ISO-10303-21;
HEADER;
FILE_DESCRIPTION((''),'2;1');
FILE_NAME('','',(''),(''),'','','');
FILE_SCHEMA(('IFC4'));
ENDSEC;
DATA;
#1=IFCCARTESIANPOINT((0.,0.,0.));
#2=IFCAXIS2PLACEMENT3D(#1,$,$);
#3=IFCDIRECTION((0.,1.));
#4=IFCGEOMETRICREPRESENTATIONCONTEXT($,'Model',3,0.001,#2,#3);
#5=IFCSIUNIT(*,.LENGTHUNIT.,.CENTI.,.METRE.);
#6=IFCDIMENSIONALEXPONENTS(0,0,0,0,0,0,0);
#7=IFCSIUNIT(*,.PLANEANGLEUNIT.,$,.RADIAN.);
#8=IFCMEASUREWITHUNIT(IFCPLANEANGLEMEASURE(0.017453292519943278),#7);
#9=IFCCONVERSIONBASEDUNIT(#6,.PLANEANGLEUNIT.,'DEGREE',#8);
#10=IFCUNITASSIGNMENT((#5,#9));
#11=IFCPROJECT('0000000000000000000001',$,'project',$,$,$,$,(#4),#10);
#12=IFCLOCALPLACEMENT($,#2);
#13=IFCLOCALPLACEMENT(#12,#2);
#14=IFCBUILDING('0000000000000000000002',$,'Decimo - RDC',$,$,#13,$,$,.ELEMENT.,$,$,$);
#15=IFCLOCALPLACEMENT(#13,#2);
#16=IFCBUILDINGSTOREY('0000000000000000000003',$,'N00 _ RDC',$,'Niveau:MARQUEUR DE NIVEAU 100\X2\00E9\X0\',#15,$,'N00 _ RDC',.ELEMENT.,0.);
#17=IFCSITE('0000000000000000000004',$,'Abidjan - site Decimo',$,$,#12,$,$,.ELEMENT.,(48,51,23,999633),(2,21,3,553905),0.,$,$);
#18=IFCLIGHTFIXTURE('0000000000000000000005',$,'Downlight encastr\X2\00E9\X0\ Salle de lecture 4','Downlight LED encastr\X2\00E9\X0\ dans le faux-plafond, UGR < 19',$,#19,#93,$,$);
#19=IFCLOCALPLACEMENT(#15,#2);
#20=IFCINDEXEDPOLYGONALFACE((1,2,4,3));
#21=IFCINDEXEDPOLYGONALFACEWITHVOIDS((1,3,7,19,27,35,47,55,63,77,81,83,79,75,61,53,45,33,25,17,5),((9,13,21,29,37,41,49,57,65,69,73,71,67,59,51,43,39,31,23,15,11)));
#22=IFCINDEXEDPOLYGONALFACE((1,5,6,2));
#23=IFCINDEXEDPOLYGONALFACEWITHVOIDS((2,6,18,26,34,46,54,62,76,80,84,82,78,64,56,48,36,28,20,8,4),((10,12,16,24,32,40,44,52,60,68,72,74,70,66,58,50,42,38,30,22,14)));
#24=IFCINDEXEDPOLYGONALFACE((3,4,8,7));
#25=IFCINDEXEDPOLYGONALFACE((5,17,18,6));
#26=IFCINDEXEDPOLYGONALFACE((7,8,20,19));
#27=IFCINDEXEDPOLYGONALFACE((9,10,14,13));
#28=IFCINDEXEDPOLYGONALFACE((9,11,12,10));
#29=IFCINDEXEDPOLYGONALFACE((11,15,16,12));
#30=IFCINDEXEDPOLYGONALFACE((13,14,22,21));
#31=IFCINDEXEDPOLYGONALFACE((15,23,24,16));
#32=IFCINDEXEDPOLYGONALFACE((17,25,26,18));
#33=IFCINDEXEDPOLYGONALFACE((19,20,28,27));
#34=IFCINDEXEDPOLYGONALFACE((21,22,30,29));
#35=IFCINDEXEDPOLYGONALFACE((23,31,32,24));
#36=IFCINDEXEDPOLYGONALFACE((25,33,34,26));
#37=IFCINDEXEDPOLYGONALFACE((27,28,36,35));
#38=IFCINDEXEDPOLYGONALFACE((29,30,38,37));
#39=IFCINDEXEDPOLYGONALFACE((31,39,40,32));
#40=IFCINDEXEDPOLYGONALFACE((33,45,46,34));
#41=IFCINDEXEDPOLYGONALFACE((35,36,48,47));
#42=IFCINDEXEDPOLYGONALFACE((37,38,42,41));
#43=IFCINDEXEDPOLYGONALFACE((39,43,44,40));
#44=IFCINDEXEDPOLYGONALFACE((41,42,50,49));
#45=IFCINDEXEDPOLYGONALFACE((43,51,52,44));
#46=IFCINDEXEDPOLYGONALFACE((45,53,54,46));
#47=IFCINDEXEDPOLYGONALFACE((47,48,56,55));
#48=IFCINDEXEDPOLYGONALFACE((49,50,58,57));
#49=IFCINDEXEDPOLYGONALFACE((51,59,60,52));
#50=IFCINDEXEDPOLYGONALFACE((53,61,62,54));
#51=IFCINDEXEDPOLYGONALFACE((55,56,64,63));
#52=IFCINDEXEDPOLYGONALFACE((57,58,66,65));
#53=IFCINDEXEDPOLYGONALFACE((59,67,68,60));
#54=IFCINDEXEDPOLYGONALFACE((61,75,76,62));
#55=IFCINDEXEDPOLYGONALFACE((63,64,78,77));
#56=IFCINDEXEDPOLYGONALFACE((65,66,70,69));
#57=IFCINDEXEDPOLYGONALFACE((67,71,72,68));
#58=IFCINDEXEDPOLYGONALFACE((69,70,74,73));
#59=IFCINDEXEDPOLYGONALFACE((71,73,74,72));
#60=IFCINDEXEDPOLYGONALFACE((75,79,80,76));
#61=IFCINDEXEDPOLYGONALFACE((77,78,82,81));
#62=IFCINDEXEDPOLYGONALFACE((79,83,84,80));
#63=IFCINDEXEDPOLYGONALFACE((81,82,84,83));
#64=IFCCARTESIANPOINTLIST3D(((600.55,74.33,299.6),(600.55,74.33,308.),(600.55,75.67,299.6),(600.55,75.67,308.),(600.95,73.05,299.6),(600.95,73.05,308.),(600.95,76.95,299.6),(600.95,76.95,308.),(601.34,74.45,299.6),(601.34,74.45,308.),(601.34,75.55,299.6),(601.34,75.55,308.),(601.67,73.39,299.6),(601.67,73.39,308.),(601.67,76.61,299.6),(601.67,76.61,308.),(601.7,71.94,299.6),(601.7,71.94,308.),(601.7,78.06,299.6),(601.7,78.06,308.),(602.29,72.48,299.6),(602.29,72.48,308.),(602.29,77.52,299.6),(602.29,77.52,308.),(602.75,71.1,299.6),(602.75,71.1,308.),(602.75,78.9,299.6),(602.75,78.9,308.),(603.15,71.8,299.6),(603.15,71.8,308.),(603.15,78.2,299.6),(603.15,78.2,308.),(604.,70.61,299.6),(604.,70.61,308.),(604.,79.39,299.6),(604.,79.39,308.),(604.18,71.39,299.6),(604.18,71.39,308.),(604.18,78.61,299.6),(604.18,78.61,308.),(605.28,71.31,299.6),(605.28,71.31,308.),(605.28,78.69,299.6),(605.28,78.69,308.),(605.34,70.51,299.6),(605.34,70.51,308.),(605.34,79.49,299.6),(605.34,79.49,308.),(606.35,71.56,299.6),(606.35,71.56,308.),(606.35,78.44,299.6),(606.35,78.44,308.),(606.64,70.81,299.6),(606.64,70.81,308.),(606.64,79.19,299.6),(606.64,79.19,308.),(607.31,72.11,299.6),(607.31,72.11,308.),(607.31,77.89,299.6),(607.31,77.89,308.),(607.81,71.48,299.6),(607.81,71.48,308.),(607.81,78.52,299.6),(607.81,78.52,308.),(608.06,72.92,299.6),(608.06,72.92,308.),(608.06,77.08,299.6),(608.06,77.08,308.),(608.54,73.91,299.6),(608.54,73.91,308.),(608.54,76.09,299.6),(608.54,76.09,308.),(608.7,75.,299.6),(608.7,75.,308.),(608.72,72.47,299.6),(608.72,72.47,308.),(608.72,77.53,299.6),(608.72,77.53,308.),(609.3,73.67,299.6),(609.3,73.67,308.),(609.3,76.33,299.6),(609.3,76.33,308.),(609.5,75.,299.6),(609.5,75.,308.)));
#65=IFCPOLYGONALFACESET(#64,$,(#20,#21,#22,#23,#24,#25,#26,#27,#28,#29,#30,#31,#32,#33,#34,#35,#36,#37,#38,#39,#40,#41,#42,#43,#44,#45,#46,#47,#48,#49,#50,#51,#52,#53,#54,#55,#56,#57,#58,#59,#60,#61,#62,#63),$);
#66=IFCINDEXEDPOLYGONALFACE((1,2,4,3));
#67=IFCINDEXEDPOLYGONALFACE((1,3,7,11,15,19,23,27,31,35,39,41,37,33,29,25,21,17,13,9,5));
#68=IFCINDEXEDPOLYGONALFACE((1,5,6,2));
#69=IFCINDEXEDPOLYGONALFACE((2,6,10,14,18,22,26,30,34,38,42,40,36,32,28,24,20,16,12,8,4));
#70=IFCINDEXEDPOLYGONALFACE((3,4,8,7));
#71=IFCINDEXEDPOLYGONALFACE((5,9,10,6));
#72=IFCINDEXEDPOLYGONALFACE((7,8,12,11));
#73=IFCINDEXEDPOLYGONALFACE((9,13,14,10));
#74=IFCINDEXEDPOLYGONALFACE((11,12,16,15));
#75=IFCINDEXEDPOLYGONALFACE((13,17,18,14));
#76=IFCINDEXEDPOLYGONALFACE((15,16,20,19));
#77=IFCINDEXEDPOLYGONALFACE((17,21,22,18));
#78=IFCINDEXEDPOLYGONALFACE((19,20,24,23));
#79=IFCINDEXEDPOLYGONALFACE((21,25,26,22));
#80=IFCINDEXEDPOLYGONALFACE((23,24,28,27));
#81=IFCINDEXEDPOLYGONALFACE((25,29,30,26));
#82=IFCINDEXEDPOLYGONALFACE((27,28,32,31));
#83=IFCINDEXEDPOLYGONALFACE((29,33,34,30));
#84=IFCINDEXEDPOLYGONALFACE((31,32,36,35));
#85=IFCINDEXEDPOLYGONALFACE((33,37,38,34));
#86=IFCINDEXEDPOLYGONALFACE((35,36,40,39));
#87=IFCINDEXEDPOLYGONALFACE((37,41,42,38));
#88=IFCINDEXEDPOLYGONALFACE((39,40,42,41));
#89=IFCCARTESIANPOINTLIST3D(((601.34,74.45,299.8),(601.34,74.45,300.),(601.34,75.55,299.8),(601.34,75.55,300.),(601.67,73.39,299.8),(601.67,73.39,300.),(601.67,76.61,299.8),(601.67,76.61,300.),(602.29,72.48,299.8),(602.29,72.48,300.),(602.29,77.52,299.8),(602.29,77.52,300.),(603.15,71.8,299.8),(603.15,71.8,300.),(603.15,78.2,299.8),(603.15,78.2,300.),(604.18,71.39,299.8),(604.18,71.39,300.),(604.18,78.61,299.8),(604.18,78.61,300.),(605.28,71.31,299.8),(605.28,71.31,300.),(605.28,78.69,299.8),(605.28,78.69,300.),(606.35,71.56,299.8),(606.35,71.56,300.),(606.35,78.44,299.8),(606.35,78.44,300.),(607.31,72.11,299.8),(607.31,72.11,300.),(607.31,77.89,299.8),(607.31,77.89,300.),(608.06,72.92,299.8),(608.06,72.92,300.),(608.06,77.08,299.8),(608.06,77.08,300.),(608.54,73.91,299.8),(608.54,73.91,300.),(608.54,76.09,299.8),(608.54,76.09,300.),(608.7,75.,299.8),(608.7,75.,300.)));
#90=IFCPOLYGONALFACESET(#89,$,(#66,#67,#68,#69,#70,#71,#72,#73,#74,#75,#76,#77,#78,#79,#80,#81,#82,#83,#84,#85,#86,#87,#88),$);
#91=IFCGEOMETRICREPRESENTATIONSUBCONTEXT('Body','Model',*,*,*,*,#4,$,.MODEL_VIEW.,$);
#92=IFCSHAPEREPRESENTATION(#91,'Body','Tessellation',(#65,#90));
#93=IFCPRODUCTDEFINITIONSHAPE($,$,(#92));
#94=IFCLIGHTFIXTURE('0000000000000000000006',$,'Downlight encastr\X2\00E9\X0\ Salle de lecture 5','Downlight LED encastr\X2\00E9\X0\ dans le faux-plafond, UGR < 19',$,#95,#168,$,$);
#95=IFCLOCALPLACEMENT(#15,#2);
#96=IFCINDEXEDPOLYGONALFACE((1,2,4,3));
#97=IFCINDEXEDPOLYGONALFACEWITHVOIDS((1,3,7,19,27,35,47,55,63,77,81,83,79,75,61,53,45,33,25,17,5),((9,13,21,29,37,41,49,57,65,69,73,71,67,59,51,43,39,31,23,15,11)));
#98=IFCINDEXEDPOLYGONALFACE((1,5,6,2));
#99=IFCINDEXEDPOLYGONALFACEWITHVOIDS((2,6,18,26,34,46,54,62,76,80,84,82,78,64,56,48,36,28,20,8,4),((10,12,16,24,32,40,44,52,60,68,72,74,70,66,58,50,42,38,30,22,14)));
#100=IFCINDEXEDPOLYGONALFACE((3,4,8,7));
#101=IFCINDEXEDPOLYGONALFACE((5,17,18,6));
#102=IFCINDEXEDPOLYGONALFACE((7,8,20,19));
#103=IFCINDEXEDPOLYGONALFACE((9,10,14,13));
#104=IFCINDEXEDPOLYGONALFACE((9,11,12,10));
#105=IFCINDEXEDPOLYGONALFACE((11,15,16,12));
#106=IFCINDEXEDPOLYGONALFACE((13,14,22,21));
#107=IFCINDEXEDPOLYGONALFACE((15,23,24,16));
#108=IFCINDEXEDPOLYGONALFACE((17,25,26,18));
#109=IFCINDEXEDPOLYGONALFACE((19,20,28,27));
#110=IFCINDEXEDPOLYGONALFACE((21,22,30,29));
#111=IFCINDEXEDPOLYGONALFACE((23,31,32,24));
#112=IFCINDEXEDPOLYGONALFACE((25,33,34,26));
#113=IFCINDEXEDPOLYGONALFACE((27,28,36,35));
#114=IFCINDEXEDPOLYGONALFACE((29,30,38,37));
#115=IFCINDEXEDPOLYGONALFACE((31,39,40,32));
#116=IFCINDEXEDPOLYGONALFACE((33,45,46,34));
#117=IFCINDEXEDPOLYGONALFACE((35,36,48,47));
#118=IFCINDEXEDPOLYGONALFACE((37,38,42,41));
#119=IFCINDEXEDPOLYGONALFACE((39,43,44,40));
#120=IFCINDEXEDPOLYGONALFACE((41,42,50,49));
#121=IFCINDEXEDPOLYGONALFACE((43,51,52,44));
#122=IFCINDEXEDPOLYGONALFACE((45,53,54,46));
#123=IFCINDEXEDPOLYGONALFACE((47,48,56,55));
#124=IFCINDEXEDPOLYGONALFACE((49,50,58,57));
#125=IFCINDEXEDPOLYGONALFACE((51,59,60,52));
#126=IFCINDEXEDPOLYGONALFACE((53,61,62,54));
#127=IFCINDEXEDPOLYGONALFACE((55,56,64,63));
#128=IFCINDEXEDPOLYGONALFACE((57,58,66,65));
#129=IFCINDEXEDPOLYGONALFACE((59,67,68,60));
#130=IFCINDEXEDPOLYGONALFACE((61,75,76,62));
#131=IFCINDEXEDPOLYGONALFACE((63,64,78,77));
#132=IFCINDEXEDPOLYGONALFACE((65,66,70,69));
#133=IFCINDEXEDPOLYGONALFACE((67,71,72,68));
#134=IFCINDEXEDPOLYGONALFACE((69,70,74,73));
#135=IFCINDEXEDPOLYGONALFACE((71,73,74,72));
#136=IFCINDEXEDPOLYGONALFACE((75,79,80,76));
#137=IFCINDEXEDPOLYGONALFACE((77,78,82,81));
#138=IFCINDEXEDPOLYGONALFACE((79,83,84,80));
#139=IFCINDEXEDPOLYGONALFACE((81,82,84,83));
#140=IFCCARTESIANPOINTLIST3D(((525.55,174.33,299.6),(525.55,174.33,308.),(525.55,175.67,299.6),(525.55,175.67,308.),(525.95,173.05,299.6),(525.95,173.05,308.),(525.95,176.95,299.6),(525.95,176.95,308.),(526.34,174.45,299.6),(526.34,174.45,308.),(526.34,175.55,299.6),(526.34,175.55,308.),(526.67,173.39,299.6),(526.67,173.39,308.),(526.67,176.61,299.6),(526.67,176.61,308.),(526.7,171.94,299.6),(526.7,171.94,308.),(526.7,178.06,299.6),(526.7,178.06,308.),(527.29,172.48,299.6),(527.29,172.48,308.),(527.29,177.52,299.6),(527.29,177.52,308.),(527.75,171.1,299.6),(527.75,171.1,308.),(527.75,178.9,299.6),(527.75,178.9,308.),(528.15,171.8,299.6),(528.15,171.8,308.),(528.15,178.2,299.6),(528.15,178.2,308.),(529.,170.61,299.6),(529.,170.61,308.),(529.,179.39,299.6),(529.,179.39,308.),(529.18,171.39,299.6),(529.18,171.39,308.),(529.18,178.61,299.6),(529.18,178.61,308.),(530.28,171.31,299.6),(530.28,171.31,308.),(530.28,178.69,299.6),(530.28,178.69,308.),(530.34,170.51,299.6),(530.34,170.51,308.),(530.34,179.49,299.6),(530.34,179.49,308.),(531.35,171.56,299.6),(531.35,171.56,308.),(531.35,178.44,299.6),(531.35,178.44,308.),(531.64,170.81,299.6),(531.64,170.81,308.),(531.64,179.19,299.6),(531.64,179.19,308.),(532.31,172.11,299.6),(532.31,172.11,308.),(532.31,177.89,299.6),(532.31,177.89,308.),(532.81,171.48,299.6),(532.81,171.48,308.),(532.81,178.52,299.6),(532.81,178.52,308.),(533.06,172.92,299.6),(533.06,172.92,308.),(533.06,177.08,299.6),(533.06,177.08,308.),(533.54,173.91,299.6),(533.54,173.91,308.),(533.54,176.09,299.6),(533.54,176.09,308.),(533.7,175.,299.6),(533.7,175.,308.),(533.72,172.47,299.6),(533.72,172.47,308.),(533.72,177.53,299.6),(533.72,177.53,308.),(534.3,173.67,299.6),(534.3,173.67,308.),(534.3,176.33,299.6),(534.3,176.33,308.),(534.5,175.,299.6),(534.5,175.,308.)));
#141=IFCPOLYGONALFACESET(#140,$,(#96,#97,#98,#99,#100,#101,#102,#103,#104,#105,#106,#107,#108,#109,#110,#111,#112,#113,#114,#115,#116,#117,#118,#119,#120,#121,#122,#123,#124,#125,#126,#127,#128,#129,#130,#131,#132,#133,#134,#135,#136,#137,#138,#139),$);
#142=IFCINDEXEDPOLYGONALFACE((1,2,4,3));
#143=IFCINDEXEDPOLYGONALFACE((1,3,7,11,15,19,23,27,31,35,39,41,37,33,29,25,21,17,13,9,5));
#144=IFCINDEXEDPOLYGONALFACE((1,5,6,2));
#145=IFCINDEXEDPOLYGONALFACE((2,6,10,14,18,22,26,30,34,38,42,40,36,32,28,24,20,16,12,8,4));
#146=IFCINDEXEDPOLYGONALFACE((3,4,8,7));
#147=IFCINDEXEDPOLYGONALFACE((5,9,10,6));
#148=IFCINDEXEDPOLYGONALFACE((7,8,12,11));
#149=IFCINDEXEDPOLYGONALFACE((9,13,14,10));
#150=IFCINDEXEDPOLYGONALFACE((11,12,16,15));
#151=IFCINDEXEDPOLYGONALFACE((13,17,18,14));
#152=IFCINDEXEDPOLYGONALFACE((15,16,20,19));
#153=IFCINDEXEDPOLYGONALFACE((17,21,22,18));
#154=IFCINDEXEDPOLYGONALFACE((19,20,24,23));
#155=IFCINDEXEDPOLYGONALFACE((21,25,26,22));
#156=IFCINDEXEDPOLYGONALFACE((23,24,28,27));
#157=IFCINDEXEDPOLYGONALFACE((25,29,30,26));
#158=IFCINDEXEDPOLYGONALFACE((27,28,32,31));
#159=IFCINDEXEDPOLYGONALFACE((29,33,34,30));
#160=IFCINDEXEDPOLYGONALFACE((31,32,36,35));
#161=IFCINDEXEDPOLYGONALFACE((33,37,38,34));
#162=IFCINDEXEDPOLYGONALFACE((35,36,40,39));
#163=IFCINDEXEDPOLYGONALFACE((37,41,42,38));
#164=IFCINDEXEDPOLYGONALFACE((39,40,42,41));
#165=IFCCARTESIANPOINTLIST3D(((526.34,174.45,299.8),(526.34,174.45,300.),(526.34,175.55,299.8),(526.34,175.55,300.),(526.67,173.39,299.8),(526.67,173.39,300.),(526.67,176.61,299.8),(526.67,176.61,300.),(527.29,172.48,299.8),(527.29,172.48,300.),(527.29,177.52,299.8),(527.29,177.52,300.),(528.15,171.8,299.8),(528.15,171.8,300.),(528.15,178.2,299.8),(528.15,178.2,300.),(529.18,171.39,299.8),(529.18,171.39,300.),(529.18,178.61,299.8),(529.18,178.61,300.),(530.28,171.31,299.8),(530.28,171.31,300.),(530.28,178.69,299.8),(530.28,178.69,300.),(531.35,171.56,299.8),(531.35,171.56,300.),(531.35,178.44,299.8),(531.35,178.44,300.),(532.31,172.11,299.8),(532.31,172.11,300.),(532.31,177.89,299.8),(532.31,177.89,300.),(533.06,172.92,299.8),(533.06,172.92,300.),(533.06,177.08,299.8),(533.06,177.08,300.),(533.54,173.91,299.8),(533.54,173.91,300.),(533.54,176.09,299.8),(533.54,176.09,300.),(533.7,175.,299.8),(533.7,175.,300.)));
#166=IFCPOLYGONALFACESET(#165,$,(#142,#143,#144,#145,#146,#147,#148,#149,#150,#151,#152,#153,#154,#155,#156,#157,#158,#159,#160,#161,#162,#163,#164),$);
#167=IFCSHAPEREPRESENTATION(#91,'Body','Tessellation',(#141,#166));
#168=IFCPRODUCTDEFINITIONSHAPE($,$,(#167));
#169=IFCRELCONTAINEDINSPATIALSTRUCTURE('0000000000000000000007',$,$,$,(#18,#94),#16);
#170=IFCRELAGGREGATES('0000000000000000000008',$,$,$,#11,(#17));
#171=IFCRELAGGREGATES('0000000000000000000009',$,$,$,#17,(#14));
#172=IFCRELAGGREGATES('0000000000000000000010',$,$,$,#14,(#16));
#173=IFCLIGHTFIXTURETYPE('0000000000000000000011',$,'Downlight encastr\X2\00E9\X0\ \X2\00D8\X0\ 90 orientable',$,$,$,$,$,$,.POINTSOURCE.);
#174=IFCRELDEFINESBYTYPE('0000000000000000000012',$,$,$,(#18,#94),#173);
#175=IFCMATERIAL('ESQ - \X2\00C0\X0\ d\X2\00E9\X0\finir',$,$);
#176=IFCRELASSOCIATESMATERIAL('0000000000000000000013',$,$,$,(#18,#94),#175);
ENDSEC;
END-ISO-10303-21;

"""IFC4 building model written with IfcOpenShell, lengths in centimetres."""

from ifc_helpers import new_model, entity, si_unit, converted_unit, direction, frame, frame_2d, origin, origin_with_axes, place, context, subcontext, project, spatial, circle, hollow_circle, extrude, material, type_object, element, save


model = new_model("IFC4")

# Units and contexts
model_context = context("Model", 3, precision=0.001, world=origin(), true_north=direction((0.0, 1.0)))
body_context = subcontext(model_context, "Body", "Model", "MODEL_VIEW")
ifc_project = project(units=[si_unit("LENGTHUNIT", "METRE", prefix="CENTI"), converted_unit("PLANEANGLEUNIT", "DEGREE", entity("IfcPlaneAngleMeasure", 0.017453292519943278), si_unit("PLANEANGLEUNIT", "RADIAN"), dimensions=[0, 0, 0, 0, 0, 0, 0])], contexts=[model_context])

# Site, building, storey
site_placement = place(None, origin())
site = spatial("IfcSite", under=ifc_project, at=site_placement, Name="Abidjan - site Decimo", CompositionType="ELEMENT", RefLatitude=(48, 51, 23, 999633), RefLongitude=(2, 21, 3, 553905), RefElevation=0.0)
building_placement = place(site_placement, origin())
building = spatial("IfcBuilding", under=site, at=building_placement, Name="Decimo - RDC", CompositionType="ELEMENT")
storey_placement = place(building_placement, origin())
storey = spatial("IfcBuildingStorey", under=building, at=storey_placement, Name="N00 _ RDC", ObjectType="Niveau:MARQUEUR DE NIVEAU 100é", LongName="N00 _ RDC", CompositionType="ELEMENT", Elevation=0.0)

# Light fixtures
ifc_material_1 = material(Name="ESQ - À définir")
light_fixture_type_1 = type_object("IfcLightFixtureType", Name="Downlight encastré Ø 90 orientable", PredefinedType="POINTSOURCE")
light_fixture_1_placement = place(storey_placement, origin_with_axes())
element("IfcLightFixture", 1, at=light_fixture_1_placement, inside=storey, type_object=light_fixture_type_1, material=ifc_material_1, Name="Downlight encastré Salle de lecture 4", Description="Downlight LED encastré dans le faux-plafond, UGR < 19", context=body_context, shape_type="SweptSolid", body=[
    extrude(hollow_circle(Radius=4.5, WallThickness=0.8, at=frame_2d((605.0, 75.0))), frame((0.0, 0.0, 299.6)), (0.0, 0.0, 1.0), 8.4),
    extrude(circle(Radius=3.7, at=frame_2d((605.0, 75.0))), frame((0.0, 0.0, 299.8)), (0.0, 0.0, 1.0), 0.2),
])
light_fixture_2_placement = place(storey_placement, origin_with_axes())
element("IfcLightFixture", 2, at=light_fixture_2_placement, inside=storey, type_object=light_fixture_type_1, material=ifc_material_1, Name="Downlight encastré Salle de lecture 5", Description="Downlight LED encastré dans le faux-plafond, UGR < 19", context=body_context, shape_type="SweptSolid", body=[
    extrude(hollow_circle(Radius=4.5, WallThickness=0.8, at=frame_2d((530.0, 175.0))), frame((0.0, 0.0, 299.6)), (0.0, 0.0, 1.0), 8.4),
    extrude(circle(Radius=3.7, at=frame_2d((530.0, 175.0))), frame((0.0, 0.0, 299.8)), (0.0, 0.0, 1.0), 0.2),
])

save(model, "model.ifc")
